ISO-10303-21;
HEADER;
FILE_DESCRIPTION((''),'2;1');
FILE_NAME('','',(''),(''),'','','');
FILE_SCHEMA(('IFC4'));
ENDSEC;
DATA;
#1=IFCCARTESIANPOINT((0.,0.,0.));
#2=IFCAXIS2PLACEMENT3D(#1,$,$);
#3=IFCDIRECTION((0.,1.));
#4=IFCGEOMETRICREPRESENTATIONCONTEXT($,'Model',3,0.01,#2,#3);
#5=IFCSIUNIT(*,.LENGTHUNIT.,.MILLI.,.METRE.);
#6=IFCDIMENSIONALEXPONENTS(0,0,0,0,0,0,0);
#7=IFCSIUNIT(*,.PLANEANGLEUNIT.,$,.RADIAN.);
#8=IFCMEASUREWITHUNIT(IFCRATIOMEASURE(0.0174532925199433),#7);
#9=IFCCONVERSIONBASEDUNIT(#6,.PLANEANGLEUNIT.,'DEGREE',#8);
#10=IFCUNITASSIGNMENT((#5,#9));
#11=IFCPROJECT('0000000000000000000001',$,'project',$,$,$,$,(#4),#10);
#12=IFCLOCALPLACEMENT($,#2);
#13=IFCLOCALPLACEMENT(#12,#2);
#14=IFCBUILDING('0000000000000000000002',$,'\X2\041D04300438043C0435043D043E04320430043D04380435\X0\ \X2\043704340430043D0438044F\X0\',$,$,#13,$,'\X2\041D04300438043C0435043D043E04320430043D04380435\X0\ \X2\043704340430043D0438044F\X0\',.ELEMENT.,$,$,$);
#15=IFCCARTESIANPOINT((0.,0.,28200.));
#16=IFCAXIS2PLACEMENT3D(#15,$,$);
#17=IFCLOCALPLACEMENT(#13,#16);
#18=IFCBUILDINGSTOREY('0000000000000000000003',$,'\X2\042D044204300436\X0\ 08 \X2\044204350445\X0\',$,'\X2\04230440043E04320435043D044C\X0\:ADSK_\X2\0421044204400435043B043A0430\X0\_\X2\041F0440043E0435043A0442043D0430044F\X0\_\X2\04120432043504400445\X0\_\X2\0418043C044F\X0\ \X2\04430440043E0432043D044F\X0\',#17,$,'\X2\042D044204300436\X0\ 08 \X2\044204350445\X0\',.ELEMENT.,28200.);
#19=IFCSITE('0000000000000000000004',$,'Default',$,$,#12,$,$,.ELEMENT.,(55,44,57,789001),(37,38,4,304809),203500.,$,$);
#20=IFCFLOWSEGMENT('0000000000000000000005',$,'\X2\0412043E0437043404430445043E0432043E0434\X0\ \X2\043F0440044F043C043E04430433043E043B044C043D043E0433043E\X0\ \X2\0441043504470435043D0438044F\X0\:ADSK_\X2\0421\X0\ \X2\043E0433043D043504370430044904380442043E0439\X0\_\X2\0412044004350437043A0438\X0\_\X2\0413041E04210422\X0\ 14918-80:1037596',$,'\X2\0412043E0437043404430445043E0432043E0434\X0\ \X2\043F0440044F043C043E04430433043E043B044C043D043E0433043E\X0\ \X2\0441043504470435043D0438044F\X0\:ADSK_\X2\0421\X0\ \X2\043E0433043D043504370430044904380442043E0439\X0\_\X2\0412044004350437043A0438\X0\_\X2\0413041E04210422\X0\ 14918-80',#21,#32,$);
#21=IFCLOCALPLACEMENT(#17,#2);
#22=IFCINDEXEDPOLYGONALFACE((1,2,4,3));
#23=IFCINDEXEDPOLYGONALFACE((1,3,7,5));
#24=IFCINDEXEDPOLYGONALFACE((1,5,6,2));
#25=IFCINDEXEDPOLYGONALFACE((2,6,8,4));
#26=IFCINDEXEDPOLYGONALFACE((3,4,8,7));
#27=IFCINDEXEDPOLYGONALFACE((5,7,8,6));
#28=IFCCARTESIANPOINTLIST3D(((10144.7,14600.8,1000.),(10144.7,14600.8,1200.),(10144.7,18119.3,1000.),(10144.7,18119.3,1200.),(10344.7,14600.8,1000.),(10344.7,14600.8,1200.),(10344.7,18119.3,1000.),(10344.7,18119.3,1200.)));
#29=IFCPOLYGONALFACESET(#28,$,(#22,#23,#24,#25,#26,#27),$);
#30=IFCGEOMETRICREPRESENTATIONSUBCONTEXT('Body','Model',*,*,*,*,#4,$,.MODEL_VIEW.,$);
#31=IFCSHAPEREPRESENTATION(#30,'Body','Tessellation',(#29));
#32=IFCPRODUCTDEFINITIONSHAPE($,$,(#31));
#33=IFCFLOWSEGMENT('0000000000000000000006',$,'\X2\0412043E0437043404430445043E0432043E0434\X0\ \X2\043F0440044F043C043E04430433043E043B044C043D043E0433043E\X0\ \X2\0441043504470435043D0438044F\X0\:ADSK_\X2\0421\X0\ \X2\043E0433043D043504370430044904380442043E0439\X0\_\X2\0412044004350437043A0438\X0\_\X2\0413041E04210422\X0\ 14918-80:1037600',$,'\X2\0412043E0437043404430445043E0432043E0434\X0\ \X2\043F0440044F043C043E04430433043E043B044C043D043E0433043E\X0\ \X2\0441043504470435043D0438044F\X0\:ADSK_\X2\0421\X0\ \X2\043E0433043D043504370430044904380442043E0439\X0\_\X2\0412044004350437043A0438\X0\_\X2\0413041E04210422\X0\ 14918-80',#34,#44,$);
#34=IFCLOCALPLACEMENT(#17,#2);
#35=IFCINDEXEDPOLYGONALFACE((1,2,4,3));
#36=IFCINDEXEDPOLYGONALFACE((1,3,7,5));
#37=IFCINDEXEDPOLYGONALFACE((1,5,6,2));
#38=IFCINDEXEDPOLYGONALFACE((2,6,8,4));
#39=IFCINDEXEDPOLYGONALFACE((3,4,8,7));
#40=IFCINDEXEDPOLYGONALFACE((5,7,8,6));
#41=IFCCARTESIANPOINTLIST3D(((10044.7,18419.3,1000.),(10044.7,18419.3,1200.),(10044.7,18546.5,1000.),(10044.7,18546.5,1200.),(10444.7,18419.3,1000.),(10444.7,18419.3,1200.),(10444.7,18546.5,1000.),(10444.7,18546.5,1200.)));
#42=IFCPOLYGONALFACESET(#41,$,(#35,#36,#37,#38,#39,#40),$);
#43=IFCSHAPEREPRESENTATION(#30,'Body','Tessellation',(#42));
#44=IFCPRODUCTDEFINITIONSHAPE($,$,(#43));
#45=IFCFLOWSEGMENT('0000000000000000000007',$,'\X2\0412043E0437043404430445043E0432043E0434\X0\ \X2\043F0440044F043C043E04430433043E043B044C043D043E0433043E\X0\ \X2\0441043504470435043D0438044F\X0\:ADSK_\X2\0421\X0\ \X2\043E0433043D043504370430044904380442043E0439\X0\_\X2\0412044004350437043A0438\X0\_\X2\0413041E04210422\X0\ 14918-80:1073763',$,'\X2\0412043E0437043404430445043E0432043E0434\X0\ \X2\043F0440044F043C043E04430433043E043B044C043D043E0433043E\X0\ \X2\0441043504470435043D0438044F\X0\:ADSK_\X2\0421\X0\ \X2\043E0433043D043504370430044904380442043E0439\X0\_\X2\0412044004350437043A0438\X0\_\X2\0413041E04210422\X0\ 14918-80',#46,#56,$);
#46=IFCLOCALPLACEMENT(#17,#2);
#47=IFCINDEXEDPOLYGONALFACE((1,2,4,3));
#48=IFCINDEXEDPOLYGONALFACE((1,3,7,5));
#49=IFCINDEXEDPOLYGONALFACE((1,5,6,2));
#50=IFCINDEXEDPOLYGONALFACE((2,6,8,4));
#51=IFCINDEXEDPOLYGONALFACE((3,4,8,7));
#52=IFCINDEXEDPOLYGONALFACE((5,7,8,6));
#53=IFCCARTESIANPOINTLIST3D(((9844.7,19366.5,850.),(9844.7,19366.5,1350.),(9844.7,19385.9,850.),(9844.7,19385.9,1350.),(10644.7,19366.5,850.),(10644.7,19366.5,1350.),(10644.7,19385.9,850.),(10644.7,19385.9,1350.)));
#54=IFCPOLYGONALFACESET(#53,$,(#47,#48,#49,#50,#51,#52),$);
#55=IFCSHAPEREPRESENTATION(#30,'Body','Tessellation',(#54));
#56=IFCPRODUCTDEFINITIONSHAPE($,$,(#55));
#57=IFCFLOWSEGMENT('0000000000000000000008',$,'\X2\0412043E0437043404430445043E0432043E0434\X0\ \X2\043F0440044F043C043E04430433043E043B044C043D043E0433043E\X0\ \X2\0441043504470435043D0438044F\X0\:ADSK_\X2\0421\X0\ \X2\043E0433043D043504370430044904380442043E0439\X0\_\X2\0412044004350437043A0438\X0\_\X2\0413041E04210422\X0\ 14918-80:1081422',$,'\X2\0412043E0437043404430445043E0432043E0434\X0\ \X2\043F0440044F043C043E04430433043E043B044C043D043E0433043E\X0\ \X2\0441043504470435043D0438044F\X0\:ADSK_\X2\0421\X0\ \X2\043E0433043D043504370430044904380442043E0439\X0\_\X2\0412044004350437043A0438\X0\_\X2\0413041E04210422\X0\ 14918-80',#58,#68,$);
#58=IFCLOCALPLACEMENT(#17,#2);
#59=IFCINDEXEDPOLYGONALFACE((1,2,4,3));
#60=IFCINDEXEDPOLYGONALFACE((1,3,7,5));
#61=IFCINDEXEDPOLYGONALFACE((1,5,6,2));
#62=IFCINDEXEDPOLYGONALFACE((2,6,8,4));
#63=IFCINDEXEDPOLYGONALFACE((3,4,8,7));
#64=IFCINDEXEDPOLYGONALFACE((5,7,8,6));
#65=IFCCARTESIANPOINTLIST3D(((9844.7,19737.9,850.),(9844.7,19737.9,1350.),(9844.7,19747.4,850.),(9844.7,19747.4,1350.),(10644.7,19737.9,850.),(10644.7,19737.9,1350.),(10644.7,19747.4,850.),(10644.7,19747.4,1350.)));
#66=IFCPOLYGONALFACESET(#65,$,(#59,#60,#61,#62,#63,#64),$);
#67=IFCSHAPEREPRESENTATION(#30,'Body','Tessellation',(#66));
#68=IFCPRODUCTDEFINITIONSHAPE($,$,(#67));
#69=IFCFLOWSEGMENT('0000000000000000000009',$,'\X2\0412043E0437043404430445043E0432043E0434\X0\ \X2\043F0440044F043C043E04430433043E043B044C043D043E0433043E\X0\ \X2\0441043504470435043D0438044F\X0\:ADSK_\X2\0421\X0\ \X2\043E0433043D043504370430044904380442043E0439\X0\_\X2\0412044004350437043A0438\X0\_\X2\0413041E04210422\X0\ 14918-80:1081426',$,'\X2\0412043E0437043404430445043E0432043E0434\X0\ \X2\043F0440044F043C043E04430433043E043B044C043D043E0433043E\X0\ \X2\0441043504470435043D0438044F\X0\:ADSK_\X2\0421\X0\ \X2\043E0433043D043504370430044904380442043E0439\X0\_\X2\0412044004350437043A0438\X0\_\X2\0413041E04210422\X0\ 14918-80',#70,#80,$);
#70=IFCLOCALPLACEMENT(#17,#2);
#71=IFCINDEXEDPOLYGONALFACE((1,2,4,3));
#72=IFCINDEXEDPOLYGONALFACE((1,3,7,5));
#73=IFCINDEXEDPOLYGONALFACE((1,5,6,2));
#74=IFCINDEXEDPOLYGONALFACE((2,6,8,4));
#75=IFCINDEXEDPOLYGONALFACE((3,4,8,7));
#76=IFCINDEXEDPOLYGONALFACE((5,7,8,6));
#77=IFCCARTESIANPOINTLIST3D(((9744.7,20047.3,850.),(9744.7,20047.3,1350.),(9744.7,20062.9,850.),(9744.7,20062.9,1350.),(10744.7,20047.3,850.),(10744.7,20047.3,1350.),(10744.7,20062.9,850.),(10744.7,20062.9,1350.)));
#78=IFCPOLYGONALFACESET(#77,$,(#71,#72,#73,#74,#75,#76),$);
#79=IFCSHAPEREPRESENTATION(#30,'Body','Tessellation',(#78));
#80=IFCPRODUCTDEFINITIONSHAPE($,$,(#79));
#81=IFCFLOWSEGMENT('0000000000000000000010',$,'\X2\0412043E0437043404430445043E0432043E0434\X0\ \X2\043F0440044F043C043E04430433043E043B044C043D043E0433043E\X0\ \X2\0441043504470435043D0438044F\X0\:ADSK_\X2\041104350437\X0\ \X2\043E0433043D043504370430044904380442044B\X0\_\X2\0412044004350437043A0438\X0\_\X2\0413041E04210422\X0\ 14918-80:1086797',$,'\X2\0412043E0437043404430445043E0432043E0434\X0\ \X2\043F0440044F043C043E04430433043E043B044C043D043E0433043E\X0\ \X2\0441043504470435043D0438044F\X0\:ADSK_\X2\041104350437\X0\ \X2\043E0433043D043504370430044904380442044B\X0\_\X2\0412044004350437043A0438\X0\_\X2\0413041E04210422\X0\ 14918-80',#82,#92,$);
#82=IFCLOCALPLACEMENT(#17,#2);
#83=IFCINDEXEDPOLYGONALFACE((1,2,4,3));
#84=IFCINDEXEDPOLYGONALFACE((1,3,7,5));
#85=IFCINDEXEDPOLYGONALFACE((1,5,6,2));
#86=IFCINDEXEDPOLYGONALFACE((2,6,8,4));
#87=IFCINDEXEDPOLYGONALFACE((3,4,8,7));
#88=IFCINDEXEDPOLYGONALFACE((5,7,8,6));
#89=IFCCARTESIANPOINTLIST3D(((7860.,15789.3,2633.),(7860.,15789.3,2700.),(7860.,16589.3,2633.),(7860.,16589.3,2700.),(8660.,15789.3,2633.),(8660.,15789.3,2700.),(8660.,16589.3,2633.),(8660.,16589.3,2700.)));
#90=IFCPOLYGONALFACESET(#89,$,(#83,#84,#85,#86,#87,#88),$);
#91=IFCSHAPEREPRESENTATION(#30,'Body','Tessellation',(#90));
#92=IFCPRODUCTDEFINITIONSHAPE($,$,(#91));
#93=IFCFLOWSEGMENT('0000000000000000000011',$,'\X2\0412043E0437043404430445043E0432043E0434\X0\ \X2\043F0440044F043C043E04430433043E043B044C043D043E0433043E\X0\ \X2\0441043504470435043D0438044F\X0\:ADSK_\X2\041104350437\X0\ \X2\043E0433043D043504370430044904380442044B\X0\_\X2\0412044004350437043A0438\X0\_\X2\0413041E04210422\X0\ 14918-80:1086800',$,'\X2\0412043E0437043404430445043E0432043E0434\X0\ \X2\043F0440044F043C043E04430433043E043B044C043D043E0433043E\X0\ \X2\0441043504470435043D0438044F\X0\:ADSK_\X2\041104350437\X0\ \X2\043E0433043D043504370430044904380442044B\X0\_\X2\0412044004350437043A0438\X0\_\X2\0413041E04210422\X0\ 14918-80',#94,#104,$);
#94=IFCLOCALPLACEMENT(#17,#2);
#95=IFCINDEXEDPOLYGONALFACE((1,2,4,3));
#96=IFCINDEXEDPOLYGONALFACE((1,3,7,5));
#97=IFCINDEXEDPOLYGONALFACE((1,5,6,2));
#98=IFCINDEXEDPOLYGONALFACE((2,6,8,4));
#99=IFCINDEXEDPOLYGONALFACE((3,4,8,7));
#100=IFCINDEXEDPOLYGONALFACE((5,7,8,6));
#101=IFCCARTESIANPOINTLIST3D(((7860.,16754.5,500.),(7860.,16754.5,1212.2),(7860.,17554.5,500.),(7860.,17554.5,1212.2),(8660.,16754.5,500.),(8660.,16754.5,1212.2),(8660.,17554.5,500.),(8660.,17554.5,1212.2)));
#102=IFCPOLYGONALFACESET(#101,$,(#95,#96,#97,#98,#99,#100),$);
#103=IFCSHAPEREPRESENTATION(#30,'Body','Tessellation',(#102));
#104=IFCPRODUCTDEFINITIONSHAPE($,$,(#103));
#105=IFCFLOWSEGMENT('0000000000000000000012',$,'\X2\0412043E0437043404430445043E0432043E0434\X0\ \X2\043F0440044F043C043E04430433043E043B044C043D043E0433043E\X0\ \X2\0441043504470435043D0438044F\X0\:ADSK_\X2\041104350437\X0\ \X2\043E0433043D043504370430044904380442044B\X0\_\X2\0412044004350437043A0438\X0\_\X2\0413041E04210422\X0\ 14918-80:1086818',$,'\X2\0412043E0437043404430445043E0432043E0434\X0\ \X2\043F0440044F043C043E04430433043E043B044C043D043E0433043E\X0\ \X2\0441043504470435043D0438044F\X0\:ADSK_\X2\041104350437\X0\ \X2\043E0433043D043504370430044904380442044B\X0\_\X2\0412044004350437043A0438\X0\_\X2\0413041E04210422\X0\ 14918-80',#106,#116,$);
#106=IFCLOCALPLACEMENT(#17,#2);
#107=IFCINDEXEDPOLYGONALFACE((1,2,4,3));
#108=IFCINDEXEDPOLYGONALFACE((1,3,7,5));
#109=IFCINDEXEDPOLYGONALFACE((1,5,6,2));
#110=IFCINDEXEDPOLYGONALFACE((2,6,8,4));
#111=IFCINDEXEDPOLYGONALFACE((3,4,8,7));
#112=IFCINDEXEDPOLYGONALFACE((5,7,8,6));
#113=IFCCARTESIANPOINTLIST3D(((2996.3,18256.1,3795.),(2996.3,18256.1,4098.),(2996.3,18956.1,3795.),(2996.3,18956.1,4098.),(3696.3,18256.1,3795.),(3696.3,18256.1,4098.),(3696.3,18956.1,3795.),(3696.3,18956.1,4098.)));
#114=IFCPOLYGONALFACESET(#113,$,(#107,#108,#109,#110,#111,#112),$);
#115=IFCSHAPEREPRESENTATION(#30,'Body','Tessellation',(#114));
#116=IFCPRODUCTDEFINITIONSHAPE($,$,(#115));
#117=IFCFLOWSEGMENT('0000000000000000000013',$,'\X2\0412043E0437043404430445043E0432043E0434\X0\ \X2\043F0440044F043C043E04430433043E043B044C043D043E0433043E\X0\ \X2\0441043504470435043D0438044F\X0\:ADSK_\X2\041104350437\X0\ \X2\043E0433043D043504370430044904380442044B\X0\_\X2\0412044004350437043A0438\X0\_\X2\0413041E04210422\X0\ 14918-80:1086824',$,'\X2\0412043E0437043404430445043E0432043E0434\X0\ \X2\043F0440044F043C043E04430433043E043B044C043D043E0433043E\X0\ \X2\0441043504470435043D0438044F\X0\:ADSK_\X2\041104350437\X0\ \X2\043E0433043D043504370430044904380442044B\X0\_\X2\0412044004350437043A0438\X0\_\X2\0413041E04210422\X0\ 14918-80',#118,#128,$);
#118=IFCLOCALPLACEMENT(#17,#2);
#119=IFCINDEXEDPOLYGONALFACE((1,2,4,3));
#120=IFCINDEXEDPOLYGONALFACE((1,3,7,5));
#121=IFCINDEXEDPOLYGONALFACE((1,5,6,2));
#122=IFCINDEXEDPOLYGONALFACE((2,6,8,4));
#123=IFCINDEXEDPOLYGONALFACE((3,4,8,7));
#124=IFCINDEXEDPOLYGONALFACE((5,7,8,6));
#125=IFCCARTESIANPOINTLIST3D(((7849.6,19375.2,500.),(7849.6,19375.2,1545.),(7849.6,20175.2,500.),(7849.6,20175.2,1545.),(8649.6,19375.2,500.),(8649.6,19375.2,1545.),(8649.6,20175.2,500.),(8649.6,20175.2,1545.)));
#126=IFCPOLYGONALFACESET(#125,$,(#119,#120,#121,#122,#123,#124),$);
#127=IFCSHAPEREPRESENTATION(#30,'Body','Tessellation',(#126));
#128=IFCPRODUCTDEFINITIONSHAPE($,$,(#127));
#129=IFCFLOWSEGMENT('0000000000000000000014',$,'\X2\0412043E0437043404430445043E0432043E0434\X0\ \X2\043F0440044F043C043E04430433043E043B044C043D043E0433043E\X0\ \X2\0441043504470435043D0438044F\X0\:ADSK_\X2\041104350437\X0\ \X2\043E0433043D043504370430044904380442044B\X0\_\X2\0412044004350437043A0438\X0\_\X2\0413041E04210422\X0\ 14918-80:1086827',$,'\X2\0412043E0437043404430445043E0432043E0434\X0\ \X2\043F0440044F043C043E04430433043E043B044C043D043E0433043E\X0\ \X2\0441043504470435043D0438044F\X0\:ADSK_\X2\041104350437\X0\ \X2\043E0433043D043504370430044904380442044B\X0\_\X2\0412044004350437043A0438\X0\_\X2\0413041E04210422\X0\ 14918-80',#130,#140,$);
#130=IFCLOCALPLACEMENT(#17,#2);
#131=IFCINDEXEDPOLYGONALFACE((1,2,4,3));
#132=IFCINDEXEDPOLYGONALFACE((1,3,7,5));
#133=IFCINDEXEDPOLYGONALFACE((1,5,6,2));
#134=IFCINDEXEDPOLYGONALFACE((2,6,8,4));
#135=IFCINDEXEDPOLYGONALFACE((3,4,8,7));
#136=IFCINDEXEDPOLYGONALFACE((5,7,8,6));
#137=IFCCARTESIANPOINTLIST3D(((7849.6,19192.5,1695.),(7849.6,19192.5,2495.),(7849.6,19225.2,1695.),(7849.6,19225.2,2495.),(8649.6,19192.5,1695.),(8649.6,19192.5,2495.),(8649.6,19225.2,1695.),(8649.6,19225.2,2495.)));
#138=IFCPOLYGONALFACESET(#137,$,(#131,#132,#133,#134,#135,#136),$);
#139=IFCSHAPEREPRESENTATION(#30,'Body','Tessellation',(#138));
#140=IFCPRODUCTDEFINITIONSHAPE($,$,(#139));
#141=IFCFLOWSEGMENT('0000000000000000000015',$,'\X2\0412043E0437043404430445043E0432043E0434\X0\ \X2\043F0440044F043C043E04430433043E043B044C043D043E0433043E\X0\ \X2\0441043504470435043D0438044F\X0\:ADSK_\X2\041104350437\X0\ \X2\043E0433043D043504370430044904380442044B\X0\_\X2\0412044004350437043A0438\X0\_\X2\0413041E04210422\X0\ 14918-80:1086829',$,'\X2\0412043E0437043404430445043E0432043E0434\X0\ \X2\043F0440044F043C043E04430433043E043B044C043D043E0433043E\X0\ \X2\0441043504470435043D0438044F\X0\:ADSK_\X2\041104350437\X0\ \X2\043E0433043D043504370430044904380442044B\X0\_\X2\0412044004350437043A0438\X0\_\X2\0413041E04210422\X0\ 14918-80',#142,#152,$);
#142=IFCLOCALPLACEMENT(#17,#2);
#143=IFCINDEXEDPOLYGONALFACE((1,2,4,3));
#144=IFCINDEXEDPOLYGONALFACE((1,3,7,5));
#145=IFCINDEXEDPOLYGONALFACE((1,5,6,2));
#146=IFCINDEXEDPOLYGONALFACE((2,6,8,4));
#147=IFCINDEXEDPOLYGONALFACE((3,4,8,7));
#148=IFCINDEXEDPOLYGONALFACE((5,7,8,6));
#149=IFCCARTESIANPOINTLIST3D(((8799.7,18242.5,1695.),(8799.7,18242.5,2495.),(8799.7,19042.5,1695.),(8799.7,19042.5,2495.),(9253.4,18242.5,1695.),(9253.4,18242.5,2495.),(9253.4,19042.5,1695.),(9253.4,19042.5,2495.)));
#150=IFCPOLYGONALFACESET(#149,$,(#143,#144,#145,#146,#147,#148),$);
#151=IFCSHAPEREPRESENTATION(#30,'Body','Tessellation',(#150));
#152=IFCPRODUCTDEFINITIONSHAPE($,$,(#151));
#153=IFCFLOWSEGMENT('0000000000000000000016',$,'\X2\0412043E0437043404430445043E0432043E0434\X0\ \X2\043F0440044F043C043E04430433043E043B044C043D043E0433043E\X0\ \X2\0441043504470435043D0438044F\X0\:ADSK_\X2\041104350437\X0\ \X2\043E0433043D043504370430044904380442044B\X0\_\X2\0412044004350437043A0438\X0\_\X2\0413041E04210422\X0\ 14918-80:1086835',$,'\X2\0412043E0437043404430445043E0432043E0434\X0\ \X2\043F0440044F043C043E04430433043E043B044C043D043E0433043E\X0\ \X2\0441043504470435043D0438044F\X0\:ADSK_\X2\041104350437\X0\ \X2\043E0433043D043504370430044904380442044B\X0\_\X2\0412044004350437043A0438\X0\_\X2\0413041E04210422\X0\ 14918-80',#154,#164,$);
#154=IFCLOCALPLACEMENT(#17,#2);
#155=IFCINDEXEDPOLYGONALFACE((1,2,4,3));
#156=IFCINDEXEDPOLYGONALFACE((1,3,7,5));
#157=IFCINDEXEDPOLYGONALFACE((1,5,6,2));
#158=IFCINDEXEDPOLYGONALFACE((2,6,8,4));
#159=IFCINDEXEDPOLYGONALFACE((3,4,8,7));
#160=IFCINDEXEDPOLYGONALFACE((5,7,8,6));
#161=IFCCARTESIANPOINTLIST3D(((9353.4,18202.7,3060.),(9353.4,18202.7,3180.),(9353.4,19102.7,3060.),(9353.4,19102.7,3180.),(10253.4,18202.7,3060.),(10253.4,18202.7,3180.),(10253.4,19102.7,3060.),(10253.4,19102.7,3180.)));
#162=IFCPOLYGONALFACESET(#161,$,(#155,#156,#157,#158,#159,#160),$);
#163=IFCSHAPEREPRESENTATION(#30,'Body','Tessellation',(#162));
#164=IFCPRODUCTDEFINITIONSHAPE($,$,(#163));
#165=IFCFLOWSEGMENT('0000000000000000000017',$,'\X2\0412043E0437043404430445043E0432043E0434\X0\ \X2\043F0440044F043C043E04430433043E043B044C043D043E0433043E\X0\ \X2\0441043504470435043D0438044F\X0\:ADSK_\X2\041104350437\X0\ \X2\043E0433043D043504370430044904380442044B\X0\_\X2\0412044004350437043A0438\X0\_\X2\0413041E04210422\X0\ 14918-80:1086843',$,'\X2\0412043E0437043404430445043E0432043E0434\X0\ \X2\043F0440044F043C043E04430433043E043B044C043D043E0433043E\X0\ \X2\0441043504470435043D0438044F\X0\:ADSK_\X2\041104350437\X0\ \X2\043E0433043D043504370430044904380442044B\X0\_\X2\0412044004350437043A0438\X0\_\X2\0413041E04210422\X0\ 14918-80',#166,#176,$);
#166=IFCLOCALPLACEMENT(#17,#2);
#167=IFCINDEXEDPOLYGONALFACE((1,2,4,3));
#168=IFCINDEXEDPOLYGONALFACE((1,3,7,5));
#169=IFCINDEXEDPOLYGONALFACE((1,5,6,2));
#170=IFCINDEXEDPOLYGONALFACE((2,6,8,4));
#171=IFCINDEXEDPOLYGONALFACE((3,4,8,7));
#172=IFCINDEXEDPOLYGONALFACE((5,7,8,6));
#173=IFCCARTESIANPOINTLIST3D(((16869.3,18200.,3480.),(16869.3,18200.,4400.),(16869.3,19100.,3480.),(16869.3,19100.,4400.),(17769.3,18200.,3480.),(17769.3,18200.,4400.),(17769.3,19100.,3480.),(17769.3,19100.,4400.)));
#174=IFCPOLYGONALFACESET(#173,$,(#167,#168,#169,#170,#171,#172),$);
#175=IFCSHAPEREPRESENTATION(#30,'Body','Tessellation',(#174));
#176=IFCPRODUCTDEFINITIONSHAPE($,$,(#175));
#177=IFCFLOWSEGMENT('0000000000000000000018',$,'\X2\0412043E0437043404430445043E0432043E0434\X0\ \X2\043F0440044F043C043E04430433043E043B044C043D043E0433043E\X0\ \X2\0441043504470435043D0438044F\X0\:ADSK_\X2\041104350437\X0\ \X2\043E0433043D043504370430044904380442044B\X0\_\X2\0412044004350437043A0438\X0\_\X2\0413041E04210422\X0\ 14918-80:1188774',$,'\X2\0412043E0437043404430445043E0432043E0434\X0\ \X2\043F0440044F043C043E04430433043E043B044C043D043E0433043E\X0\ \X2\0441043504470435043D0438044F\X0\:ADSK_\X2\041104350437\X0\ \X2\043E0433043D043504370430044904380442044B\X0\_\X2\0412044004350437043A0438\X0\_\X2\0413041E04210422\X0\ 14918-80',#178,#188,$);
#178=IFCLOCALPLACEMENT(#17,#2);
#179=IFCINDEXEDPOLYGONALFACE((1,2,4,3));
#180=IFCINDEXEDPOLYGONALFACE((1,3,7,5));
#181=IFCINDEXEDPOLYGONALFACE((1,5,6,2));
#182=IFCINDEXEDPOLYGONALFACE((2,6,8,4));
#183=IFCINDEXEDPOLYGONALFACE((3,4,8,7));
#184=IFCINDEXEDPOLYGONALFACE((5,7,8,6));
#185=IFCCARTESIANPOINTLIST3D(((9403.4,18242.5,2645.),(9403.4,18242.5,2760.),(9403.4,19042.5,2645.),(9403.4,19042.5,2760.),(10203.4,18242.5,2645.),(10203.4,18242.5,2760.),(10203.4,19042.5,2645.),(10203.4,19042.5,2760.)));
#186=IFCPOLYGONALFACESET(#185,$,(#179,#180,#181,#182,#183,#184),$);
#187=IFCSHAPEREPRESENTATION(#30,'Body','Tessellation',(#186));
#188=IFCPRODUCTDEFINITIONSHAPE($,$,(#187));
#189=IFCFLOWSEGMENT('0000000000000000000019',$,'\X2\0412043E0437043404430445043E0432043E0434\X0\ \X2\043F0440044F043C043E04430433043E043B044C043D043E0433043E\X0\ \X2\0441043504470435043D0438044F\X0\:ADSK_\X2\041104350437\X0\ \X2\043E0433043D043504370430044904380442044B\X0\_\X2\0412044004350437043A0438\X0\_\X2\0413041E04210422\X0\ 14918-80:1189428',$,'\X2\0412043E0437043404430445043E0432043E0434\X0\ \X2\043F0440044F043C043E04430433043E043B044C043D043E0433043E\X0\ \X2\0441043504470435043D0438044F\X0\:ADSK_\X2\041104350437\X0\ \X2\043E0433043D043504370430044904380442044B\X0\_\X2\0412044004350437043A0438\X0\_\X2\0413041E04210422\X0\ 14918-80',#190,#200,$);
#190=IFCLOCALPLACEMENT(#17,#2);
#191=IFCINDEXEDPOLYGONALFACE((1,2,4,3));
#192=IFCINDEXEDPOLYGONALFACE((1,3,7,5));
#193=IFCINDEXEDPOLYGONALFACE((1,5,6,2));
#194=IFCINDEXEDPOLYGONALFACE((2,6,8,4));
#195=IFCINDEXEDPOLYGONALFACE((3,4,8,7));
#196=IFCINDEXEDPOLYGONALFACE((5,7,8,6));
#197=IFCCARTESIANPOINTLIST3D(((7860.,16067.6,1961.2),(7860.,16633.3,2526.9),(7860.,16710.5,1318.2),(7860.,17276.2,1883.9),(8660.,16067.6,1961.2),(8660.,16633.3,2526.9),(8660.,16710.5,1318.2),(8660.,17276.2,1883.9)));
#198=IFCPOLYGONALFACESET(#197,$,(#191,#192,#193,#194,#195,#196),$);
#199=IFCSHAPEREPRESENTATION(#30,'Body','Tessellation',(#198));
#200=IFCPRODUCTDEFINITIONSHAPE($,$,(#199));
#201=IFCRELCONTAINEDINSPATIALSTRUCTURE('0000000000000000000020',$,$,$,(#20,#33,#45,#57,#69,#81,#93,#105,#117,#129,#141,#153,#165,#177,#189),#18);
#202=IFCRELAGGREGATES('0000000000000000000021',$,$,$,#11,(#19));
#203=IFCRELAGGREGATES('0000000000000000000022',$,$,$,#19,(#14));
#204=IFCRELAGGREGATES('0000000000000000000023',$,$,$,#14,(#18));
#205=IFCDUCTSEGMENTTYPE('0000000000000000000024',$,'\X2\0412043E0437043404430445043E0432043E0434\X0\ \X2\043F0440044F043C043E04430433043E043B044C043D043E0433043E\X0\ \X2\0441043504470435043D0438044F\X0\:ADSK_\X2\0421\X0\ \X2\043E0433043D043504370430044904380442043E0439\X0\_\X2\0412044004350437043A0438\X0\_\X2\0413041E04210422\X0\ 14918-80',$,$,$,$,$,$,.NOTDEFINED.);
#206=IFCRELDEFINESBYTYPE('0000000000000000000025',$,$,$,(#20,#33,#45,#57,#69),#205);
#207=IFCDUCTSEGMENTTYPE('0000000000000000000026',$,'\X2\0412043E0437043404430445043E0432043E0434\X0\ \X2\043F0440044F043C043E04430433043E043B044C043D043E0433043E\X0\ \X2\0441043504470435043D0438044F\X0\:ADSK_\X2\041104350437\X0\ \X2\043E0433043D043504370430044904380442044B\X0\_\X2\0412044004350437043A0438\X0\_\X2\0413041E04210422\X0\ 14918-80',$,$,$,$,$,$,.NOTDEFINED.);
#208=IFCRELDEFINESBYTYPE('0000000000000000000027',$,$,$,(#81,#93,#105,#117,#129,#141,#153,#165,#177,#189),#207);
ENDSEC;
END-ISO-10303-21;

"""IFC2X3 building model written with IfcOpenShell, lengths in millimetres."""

from ifc_helpers import new_model, entity, si_unit, converted_unit, direction, frame, frame_2d, origin, origin_2d_with_axis, place, context, subcontext, project, spatial, rectangle, extrude, type_object, element, save


model = new_model("IFC2X3")

# Units and contexts
model_context = context("Model", 3, precision=0.01, world=origin(), true_north=direction((0.0, 1.0)))
body_context = subcontext(model_context, "Body", "Model", "MODEL_VIEW")
ifc_project = project(units=[si_unit("LENGTHUNIT", "METRE", prefix="MILLI"), converted_unit("PLANEANGLEUNIT", "DEGREE", entity("IfcRatioMeasure", 0.0174532925199433), si_unit("PLANEANGLEUNIT", "RADIAN"), dimensions=[0, 0, 0, 0, 0, 0, 0])], contexts=[model_context])

# Site, building, storey
site_placement = place(None, origin())
site = spatial("IfcSite", under=ifc_project, at=site_placement, Name="Default", CompositionType="ELEMENT", RefLatitude=(55, 44, 57, 789001), RefLongitude=(37, 38, 4, 304809), RefElevation=203500.0)
building_placement = place(site_placement, origin())
building = spatial("IfcBuilding", under=site, at=building_placement, Name="Наименование здания", LongName="Наименование здания", CompositionType="ELEMENT")
storey_placement = place(building_placement, frame((0.0, 0.0, 28200.0)))
storey = spatial("IfcBuildingStorey", under=building, at=storey_placement, Name="Этаж 08 тех", ObjectType="Уровень:ADSK_Стрелка_Проектная_Вверх_Имя уровня", LongName="Этаж 08 тех", CompositionType="ELEMENT", Elevation=28200.0)

# Flow segments
duct_segment_type_1 = type_object("IfcDuctSegmentType", Name="Воздуховод прямоугольного сечения:ADSK_С огнезащитой_Врезки_ГОСТ 14918-80", PredefinedType="NOTDEFINED")
flow_segment_1_placement = place(storey_placement, frame((10144.7, 14600.8, 1000.0)))
element("IfcFlowSegment", 1, at=flow_segment_1_placement, inside=storey, type_object=duct_segment_type_1, Name="Воздуховод прямоугольного сечения:ADSK_С огнезащитой_Врезки_ГОСТ 14918-80:1037596", ObjectType="Воздуховод прямоугольного сечения:ADSK_С огнезащитой_Врезки_ГОСТ 14918-80", context=body_context, shape_type="SweptSolid", body=[
    extrude(rectangle(XDim=3518.5, YDim=200.0, at=origin_2d_with_axis()), frame((100.0, 1759.2, 0.0), z_axis=(0.0, 0.0, 1.0), x_axis=(0.0, -1.0, 0.0)), (0.0, 0.0, 1.0), 200.0),
])
flow_segment_2_placement = place(storey_placement, frame((10044.7, 18419.3, 1000.0)))
element("IfcFlowSegment", 2, at=flow_segment_2_placement, inside=storey, type_object=duct_segment_type_1, Name="Воздуховод прямоугольного сечения:ADSK_С огнезащитой_Врезки_ГОСТ 14918-80:1037600", ObjectType="Воздуховод прямоугольного сечения:ADSK_С огнезащитой_Врезки_ГОСТ 14918-80", context=body_context, shape_type="SweptSolid", body=[
    extrude(rectangle(XDim=127.2, YDim=400.0, at=origin_2d_with_axis()), frame((200.0, 63.6, 0.0), z_axis=(0.0, 0.0, 1.0), x_axis=(0.0, 1.0, 0.0)), (0.0, 0.0, 1.0), 200.0),
])
flow_segment_3_placement = place(storey_placement, frame((9844.7, 19366.5, 850.0)))
element("IfcFlowSegment", 3, at=flow_segment_3_placement, inside=storey, type_object=duct_segment_type_1, Name="Воздуховод прямоугольного сечения:ADSK_С огнезащитой_Врезки_ГОСТ 14918-80:1073763", ObjectType="Воздуховод прямоугольного сечения:ADSK_С огнезащитой_Врезки_ГОСТ 14918-80", context=body_context, shape_type="SweptSolid", body=[
    extrude(rectangle(XDim=19.4, YDim=800.0, at=origin_2d_with_axis()), frame((400.0, 9.7, 0.0), z_axis=(0.0, 0.0, 1.0), x_axis=(0.0, -1.0, 0.0)), (0.0, 0.0, 1.0), 500.0),
])
flow_segment_4_placement = place(storey_placement, frame((9844.7, 19737.9, 850.0)))
element("IfcFlowSegment", 4, at=flow_segment_4_placement, inside=storey, type_object=duct_segment_type_1, Name="Воздуховод прямоугольного сечения:ADSK_С огнезащитой_Врезки_ГОСТ 14918-80:1081422", ObjectType="Воздуховод прямоугольного сечения:ADSK_С огнезащитой_Врезки_ГОСТ 14918-80", context=body_context, shape_type="SweptSolid", body=[
    extrude(rectangle(XDim=9.4, YDim=800.0, at=origin_2d_with_axis()), frame((400.0, 4.7, 0.0), z_axis=(0.0, 0.0, 1.0), x_axis=(0.0, -1.0, 0.0)), (0.0, 0.0, 1.0), 500.0),
])
flow_segment_5_placement = place(storey_placement, frame((9744.7, 20047.3, 850.0)))
element("IfcFlowSegment", 5, at=flow_segment_5_placement, inside=storey, type_object=duct_segment_type_1, Name="Воздуховод прямоугольного сечения:ADSK_С огнезащитой_Врезки_ГОСТ 14918-80:1081426", ObjectType="Воздуховод прямоугольного сечения:ADSK_С огнезащитой_Врезки_ГОСТ 14918-80", context=body_context, shape_type="SweptSolid", body=[
    extrude(rectangle(XDim=15.6, YDim=1000.0, at=origin_2d_with_axis()), frame((500.0, 7.8, 0.0), z_axis=(0.0, 0.0, 1.0), x_axis=(0.0, -1.0, 0.0)), (0.0, 0.0, 1.0), 500.0),
])
duct_segment_type_2 = type_object("IfcDuctSegmentType", Name="Воздуховод прямоугольного сечения:ADSK_Без огнезащиты_Врезки_ГОСТ 14918-80", PredefinedType="NOTDEFINED")
flow_segment_6_placement = place(storey_placement, frame((7860.0, 15789.3, 2633.0)))
element("IfcFlowSegment", 6, at=flow_segment_6_placement, inside=storey, type_object=duct_segment_type_2, Name="Воздуховод прямоугольного сечения:ADSK_Без огнезащиты_Врезки_ГОСТ 14918-80:1086797", ObjectType="Воздуховод прямоугольного сечения:ADSK_Без огнезащиты_Врезки_ГОСТ 14918-80", context=body_context, shape_type="SweptSolid", body=[
    extrude(rectangle(XDim=800.0, YDim=800.0, at=origin_2d_with_axis()), frame((400.0, 400.0, 0.0)), (0.0, 0.0, 1.0), 67.0),
])
flow_segment_7_placement = place(storey_placement, frame((7860.0, 16754.5, 500.0)))
element("IfcFlowSegment", 7, at=flow_segment_7_placement, inside=storey, type_object=duct_segment_type_2, Name="Воздуховод прямоугольного сечения:ADSK_Без огнезащиты_Врезки_ГОСТ 14918-80:1086800", ObjectType="Воздуховод прямоугольного сечения:ADSK_Без огнезащиты_Врезки_ГОСТ 14918-80", context=body_context, shape_type="SweptSolid", body=[
    extrude(rectangle(XDim=800.0, YDim=800.0, at=origin_2d_with_axis()), frame((400.0, 400.0, 0.0)), (0.0, 0.0, 1.0), 712.2),
])
flow_segment_8_placement = place(storey_placement, frame((2996.3, 18256.1, 3795.0)))
element("IfcFlowSegment", 8, at=flow_segment_8_placement, inside=storey, type_object=duct_segment_type_2, Name="Воздуховод прямоугольного сечения:ADSK_Без огнезащиты_Врезки_ГОСТ 14918-80:1086818", ObjectType="Воздуховод прямоугольного сечения:ADSK_Без огнезащиты_Врезки_ГОСТ 14918-80", context=body_context, shape_type="SweptSolid", body=[
    extrude(rectangle(XDim=700.0, YDim=700.0, at=origin_2d_with_axis()), frame((350.0, 350.0, 0.0)), (0.0, 0.0, 1.0), 303.0),
])
flow_segment_9_placement = place(storey_placement, frame((7849.6, 19375.2, 500.0)))
element("IfcFlowSegment", 9, at=flow_segment_9_placement, inside=storey, type_object=duct_segment_type_2, Name="Воздуховод прямоугольного сечения:ADSK_Без огнезащиты_Врезки_ГОСТ 14918-80:1086824", ObjectType="Воздуховод прямоугольного сечения:ADSK_Без огнезащиты_Врезки_ГОСТ 14918-80", context=body_context, shape_type="SweptSolid", body=[
    extrude(rectangle(XDim=800.0, YDim=800.0, at=origin_2d_with_axis()), frame((400.0, 400.0, 0.0)), (0.0, 0.0, 1.0), 1045.0),
])
flow_segment_10_placement = place(storey_placement, frame((7849.6, 19192.5, 1695.0)))
element("IfcFlowSegment", 10, at=flow_segment_10_placement, inside=storey, type_object=duct_segment_type_2, Name="Воздуховод прямоугольного сечения:ADSK_Без огнезащиты_Врезки_ГОСТ 14918-80:1086827", ObjectType="Воздуховод прямоугольного сечения:ADSK_Без огнезащиты_Врезки_ГОСТ 14918-80", context=body_context, shape_type="SweptSolid", body=[
    extrude(rectangle(XDim=32.7, YDim=800.0, at=origin_2d_with_axis()), frame((400.0, 16.3, 0.0), z_axis=(0.0, 0.0, 1.0), x_axis=(0.0, -1.0, 0.0)), (0.0, 0.0, 1.0), 800.0),
])
flow_segment_11_placement = place(storey_placement, frame((8799.6, 18242.5, 1695.0)))
element("IfcFlowSegment", 11, at=flow_segment_11_placement, inside=storey, type_object=duct_segment_type_2, Name="Воздуховод прямоугольного сечения:ADSK_Без огнезащиты_Врезки_ГОСТ 14918-80:1086829", ObjectType="Воздуховод прямоугольного сечения:ADSK_Без огнезащиты_Врезки_ГОСТ 14918-80", context=body_context, shape_type="SweptSolid", body=[
    extrude(rectangle(XDim=453.7, YDim=800.0, at=origin_2d_with_axis()), frame((226.9, 400.0, 0.0), z_axis=(0.0, 0.0, 1.0), x_axis=(-1.0, 0.0, 0.0)), (0.0, 0.0, 1.0), 800.0),
])
flow_segment_12_placement = place(storey_placement, frame((9353.4, 18202.7, 3060.0)))
element("IfcFlowSegment", 12, at=flow_segment_12_placement, inside=storey, type_object=duct_segment_type_2, Name="Воздуховод прямоугольного сечения:ADSK_Без огнезащиты_Врезки_ГОСТ 14918-80:1086835", ObjectType="Воздуховод прямоугольного сечения:ADSK_Без огнезащиты_Врезки_ГОСТ 14918-80", context=body_context, shape_type="SweptSolid", body=[
    extrude(rectangle(XDim=900.0, YDim=900.0, at=origin_2d_with_axis()), frame((450.0, 450.0, 0.0), z_axis=(0.0, 0.0, 1.0), x_axis=(0.0, -1.0, 0.0)), (0.0, 0.0, 1.0), 120.0),
])
flow_segment_13_placement = place(storey_placement, frame((16869.3, 18200.0, 3480.0)))
element("IfcFlowSegment", 13, at=flow_segment_13_placement, inside=storey, type_object=duct_segment_type_2, Name="Воздуховод прямоугольного сечения:ADSK_Без огнезащиты_Врезки_ГОСТ 14918-80:1086843", ObjectType="Воздуховод прямоугольного сечения:ADSK_Без огнезащиты_Врезки_ГОСТ 14918-80", context=body_context, shape_type="SweptSolid", body=[
    extrude(rectangle(XDim=900.0, YDim=900.0, at=origin_2d_with_axis()), frame((450.0, 450.0, 0.0)), (0.0, 0.0, 1.0), 920.0),
])
flow_segment_14_placement = place(storey_placement, frame((9403.4, 18242.5, 2645.0)))
element("IfcFlowSegment", 14, at=flow_segment_14_placement, inside=storey, type_object=duct_segment_type_2, Name="Воздуховод прямоугольного сечения:ADSK_Без огнезащиты_Врезки_ГОСТ 14918-80:1188774", ObjectType="Воздуховод прямоугольного сечения:ADSK_Без огнезащиты_Врезки_ГОСТ 14918-80", context=body_context, shape_type="SweptSolid", body=[
    extrude(rectangle(XDim=800.0, YDim=800.0, at=origin_2d_with_axis()), frame((400.0, 400.0, 0.0)), (0.0, 0.0, 1.0), 115.0),
])
flow_segment_15_placement = place(storey_placement, frame((7860.0, 16067.6, 1318.2)))
element("IfcFlowSegment", 15, at=flow_segment_15_placement, inside=storey, type_object=duct_segment_type_2, Name="Воздуховод прямоугольного сечения:ADSK_Без огнезащиты_Врезки_ГОСТ 14918-80:1189428", ObjectType="Воздуховод прямоугольного сечения:ADSK_Без огнезащиты_Врезки_ГОСТ 14918-80", context=body_context, shape_type="SweptSolid", body=[
    extrude(rectangle(XDim=800.0, YDim=800.0, at=frame_2d((0.0, 0.0), x_axis=(0.0, 1.0))), frame((400.0, 925.8, 282.8), z_axis=(0.0, -0.707107, 0.707107), x_axis=(1.0, 0.0, 0.0)), (0.0, 0.0, 1.0), 909.3),
])

save(model, "model.ifc")
